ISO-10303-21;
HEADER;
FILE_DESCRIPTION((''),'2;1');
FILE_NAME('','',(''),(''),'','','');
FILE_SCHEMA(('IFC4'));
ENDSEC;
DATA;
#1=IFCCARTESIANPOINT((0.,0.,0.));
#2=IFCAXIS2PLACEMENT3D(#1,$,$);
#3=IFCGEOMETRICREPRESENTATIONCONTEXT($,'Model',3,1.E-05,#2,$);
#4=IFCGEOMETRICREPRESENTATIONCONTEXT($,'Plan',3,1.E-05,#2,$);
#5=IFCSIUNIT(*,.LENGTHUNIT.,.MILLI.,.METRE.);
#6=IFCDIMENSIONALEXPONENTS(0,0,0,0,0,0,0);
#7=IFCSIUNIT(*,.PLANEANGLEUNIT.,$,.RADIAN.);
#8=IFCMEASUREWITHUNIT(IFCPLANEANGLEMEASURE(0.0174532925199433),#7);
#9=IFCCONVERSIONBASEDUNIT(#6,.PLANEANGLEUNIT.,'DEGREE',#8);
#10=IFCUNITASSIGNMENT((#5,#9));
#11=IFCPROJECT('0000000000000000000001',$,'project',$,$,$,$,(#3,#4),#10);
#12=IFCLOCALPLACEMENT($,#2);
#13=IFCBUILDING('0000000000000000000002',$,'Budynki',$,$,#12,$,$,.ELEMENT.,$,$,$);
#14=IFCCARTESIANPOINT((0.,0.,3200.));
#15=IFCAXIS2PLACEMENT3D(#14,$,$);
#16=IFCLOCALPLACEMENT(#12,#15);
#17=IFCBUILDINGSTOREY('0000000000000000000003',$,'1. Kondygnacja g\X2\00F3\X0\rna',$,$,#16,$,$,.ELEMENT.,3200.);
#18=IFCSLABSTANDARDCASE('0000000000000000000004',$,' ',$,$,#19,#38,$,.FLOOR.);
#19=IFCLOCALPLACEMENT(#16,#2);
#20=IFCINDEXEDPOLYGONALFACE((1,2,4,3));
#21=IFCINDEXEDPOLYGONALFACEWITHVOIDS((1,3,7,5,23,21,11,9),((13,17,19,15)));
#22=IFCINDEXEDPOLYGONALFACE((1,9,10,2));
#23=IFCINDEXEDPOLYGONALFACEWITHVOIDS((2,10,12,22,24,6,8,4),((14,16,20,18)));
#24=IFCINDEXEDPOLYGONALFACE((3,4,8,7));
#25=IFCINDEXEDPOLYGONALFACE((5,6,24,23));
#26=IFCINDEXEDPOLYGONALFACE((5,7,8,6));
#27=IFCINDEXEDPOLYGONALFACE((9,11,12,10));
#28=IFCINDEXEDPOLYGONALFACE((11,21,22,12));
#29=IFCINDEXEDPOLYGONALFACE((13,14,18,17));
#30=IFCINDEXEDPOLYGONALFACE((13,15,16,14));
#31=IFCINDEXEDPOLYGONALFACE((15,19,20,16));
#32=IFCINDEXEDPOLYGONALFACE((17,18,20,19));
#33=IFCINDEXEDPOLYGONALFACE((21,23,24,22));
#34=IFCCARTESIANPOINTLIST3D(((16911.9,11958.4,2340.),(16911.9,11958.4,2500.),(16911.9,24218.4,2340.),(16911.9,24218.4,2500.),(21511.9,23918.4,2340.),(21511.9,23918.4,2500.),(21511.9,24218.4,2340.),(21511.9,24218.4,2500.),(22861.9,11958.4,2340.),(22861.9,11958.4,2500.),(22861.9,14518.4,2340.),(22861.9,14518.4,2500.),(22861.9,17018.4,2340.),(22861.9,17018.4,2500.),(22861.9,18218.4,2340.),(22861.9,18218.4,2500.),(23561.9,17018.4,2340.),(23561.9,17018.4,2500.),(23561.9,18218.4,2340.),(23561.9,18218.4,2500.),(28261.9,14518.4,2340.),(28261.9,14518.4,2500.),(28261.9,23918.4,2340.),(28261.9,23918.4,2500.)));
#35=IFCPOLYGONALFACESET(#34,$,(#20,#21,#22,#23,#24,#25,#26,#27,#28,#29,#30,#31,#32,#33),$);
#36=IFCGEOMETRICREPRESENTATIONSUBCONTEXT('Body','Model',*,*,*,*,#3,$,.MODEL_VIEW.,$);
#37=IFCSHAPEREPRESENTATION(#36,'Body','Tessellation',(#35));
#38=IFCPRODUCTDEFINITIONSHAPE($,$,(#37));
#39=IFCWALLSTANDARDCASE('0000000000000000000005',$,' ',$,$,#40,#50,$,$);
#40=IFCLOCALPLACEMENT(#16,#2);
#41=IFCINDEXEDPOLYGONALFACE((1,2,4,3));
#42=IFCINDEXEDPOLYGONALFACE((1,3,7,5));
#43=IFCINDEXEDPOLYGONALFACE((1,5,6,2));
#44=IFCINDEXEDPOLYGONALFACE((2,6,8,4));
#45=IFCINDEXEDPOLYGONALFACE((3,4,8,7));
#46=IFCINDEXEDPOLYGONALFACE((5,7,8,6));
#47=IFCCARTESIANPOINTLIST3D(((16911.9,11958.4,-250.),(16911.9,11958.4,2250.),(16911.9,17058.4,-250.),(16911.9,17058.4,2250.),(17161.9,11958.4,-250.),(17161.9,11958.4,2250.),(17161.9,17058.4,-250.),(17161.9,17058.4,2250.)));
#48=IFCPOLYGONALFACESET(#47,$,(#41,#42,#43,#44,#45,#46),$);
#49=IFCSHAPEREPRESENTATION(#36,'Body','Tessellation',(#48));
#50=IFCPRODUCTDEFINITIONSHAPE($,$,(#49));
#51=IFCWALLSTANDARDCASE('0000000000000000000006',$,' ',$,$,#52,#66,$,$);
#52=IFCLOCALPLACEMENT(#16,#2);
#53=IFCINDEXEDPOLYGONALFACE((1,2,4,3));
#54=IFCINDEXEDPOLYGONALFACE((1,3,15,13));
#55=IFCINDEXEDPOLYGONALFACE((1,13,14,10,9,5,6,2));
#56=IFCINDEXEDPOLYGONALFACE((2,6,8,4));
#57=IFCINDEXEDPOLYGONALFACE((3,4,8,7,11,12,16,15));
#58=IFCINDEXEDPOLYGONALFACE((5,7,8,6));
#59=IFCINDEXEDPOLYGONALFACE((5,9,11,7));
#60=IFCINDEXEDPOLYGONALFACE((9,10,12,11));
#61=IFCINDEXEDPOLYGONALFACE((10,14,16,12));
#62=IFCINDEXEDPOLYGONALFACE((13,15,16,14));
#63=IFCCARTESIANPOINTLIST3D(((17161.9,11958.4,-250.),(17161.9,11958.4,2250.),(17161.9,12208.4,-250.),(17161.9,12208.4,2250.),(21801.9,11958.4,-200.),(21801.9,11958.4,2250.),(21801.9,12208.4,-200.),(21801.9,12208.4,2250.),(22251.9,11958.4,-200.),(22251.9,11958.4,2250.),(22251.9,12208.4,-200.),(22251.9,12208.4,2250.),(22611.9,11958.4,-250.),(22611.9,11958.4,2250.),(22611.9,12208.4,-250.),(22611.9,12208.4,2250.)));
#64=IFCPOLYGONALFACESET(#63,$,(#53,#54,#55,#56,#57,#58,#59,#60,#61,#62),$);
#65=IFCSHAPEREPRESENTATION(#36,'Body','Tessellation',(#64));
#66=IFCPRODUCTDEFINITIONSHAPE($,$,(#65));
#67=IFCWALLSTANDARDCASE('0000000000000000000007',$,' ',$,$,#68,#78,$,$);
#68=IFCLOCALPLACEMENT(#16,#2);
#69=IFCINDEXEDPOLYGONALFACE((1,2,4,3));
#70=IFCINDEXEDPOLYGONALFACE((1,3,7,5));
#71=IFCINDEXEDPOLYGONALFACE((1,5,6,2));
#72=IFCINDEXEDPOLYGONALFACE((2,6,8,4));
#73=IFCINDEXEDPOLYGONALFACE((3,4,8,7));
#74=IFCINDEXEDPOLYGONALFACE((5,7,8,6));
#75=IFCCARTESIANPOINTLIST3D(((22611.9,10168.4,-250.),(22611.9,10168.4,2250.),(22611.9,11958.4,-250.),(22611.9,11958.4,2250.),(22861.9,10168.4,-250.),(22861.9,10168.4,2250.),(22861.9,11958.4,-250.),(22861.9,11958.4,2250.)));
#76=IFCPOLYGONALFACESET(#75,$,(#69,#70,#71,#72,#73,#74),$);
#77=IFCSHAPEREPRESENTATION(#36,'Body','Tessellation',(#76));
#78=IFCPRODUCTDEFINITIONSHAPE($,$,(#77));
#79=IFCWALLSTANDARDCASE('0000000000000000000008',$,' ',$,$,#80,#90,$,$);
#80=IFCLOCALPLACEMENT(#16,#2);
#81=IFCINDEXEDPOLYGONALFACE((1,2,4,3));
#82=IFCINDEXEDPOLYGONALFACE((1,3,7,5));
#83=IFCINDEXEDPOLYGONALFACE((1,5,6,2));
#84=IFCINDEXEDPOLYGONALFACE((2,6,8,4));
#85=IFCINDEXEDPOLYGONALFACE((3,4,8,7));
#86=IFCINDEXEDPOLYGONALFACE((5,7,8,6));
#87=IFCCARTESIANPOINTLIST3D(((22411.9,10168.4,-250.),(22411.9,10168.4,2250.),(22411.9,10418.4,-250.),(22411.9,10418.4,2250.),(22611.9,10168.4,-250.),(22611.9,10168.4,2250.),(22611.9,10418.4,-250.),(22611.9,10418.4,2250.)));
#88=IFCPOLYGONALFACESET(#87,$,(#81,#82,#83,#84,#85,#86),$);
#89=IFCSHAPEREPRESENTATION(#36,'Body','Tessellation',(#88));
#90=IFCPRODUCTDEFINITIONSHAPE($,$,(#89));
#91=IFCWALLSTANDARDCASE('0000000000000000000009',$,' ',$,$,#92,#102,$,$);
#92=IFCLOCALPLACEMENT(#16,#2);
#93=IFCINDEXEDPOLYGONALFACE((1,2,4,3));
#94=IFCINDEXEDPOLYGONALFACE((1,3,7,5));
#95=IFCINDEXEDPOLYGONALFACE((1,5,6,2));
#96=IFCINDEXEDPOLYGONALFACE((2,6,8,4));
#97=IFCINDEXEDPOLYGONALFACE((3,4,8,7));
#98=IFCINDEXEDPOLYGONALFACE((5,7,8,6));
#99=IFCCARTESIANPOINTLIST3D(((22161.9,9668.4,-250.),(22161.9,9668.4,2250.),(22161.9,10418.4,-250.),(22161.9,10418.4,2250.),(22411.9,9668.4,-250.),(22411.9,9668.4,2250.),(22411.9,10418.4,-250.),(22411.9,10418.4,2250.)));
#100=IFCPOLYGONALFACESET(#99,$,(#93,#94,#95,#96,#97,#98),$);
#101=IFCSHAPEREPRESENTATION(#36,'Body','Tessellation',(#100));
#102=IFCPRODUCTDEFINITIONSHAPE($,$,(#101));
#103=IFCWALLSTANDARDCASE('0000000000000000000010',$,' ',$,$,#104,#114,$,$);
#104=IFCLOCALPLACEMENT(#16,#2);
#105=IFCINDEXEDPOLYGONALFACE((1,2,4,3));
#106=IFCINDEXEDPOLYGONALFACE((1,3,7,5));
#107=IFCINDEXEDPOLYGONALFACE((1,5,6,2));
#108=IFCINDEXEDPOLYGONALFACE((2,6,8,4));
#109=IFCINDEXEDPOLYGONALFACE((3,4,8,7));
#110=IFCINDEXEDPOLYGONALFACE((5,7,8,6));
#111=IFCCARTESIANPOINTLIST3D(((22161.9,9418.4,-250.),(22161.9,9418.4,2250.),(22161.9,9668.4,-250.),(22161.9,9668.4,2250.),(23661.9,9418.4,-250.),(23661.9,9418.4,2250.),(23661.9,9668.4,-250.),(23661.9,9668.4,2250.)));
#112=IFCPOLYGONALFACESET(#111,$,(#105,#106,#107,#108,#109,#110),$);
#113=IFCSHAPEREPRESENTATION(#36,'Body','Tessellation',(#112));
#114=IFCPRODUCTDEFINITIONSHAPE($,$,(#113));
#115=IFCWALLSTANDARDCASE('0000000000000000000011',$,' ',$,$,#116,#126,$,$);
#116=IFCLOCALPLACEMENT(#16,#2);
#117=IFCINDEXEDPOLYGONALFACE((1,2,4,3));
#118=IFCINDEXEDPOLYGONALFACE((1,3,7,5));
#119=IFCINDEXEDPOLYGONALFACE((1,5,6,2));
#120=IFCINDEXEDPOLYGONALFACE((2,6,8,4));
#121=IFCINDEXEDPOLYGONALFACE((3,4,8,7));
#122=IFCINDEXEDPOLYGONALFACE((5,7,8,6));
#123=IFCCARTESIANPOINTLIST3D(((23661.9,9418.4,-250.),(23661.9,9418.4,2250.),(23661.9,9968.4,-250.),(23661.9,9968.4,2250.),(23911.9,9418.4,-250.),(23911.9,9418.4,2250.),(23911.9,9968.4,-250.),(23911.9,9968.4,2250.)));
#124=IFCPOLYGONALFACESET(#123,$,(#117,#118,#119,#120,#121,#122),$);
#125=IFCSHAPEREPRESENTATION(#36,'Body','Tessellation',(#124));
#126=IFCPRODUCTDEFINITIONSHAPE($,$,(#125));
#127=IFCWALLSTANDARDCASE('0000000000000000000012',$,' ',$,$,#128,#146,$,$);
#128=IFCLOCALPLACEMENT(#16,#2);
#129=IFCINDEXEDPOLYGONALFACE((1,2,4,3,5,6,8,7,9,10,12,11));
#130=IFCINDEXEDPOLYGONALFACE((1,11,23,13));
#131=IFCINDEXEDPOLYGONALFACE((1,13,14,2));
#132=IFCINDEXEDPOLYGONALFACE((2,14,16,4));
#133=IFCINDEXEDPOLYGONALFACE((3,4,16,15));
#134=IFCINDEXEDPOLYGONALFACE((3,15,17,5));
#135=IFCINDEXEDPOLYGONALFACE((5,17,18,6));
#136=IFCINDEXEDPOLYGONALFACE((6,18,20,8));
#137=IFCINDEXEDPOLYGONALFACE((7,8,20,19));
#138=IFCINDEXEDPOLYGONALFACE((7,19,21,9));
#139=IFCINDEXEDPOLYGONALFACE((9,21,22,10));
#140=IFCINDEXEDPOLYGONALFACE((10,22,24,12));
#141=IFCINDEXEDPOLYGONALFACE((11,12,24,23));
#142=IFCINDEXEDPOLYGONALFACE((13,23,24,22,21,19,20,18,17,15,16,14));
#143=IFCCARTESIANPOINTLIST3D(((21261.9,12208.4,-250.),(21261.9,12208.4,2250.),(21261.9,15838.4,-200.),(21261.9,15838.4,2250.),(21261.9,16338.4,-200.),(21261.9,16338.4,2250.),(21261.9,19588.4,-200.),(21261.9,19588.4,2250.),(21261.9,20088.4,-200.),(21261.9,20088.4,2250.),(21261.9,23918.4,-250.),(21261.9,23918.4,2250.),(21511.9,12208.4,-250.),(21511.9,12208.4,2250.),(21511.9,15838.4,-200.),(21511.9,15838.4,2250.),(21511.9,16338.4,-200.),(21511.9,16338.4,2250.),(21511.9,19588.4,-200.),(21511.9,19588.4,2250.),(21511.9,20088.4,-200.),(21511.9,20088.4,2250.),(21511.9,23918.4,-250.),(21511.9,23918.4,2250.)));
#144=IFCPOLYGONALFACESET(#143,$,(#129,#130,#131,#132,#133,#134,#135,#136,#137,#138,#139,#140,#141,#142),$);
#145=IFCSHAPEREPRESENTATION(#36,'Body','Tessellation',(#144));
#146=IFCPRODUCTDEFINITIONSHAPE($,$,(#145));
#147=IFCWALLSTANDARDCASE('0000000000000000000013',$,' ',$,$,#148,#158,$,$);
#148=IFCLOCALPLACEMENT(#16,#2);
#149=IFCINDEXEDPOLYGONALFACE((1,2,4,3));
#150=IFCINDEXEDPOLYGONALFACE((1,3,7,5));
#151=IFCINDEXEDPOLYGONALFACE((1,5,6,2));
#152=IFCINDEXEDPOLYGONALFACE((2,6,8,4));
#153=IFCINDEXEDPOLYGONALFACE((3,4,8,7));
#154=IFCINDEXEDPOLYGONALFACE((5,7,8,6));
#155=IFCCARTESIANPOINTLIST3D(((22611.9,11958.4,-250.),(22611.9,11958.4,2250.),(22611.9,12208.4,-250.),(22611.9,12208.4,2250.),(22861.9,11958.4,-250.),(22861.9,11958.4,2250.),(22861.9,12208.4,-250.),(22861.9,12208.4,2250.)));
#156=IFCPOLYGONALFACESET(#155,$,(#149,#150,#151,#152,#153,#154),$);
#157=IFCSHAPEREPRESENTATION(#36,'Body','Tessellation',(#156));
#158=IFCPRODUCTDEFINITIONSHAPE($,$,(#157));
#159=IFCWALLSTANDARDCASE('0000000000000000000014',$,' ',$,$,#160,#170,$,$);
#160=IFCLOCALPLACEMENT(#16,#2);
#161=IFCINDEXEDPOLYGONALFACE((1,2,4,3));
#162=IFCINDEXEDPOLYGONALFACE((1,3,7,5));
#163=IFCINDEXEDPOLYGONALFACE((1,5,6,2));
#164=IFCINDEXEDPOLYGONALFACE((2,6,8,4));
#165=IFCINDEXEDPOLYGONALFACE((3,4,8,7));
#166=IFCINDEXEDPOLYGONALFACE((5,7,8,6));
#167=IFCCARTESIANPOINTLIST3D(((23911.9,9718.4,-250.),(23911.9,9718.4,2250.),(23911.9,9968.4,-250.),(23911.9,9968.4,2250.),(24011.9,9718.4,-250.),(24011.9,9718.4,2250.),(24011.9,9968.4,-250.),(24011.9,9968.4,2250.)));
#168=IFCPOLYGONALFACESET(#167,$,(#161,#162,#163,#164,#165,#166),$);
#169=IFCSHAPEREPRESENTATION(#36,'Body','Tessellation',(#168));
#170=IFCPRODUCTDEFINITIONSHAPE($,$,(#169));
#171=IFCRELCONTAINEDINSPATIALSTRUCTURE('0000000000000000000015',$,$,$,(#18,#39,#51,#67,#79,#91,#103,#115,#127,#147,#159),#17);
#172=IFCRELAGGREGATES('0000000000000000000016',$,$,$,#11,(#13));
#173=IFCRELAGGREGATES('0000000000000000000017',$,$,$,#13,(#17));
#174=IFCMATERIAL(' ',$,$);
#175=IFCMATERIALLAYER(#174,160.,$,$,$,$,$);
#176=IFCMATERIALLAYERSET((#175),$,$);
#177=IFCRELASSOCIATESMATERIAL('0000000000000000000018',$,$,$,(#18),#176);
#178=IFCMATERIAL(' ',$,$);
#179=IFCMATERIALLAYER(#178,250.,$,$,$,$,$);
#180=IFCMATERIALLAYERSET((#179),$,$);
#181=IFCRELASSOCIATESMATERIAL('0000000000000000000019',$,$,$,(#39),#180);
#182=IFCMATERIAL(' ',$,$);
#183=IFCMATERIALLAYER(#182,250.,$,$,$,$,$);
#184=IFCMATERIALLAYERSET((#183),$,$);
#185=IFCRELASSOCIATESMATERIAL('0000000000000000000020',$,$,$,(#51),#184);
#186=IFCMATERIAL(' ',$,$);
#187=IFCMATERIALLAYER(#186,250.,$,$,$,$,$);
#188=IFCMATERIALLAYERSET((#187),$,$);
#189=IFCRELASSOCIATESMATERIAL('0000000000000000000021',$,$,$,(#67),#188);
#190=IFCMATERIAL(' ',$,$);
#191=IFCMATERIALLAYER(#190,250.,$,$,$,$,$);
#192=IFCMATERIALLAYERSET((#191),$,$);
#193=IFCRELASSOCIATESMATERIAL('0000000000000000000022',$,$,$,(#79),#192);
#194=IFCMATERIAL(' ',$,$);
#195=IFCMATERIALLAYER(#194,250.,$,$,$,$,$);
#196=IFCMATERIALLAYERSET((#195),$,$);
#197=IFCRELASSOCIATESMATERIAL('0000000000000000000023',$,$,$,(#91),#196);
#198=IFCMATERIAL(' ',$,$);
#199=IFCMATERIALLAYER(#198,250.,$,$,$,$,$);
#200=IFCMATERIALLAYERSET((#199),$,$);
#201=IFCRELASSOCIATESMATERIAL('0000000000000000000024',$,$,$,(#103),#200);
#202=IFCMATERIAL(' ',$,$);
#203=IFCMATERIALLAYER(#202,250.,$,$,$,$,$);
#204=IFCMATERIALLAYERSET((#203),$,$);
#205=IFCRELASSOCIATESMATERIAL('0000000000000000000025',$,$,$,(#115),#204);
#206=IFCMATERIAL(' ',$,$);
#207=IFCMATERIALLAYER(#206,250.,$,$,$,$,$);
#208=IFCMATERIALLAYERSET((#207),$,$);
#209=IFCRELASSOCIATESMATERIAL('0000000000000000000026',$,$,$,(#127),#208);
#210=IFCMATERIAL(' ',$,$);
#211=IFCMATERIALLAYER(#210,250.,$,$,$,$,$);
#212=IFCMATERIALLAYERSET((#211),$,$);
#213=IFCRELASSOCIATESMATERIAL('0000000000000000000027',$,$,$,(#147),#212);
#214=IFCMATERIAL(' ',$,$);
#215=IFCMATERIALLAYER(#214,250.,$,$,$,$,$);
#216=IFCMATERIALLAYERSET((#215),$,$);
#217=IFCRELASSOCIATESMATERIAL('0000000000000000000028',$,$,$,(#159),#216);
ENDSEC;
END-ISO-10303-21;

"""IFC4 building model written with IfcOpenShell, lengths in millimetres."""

from ifc_helpers import new_model, entity, si_unit, converted_unit, frame, frame_2d, origin, origin_with_axes, place, context, subcontext, project, spatial, polyline, rectangle, outline, extrude, clip, bounded_halfspace, material, layer, layer_set, layer_usage, element, save


model = new_model("IFC4")

# Units and contexts
model_context = context("Model", 3, precision=1e-05, world=origin())
plan_context = context("Plan", 3, precision=1e-05, world=origin())
body_context = subcontext(model_context, "Body", "Model", "MODEL_VIEW")
ifc_project = project(units=[si_unit("LENGTHUNIT", "METRE", prefix="MILLI"), converted_unit("PLANEANGLEUNIT", "DEGREE", entity("IfcPlaneAngleMeasure", 0.0174532925199433), si_unit("PLANEANGLEUNIT", "RADIAN"), dimensions=[0, 0, 0, 0, 0, 0, 0])], contexts=[model_context, plan_context])

# Building, storey
building_placement = place(None, origin())
building = spatial("IfcBuilding", under=ifc_project, at=building_placement, Name="Budynki", CompositionType="ELEMENT")
storey_placement = place(building_placement, frame((0.0, 0.0, 3200.0)))
storey = spatial("IfcBuildingStorey", under=building, at=storey_placement, Name="1. Kondygnacja górna", CompositionType="ELEMENT", Elevation=3200.0)

# Slab
ifc_material_1 = material(Name=" ")
ifc_layer_1 = layer(ifc_material_1, 160.0)
ifc_layer_set_1 = layer_set([ifc_layer_1])
ifc_layer_usage_1 = layer_usage(ifc_layer_set_1, "AXIS3", "POSITIVE", 0.0)
slab_1_placement = place(storey_placement, frame((16911.9, 11958.4, 2340.0)))
element("IfcSlabStandardCase", 1, at=slab_1_placement, inside=storey, material=ifc_layer_usage_1, Name=" ", PredefinedType="FLOOR", context=body_context, shape_type="SweptSolid", body=[
    extrude(outline(polyline([(0.0, 0.0), (5950.0, 0.0), (5950.0, 2560.0), (11350.0, 2560.0), (11350.0, 11960.0), (4600.0, 11960.0), (4600.0, 12260.0), (0.0, 12260.0), (0.0, 0.0)]), holes=[polyline([(5950.0, 5060.0), (5950.0, 6260.0), (6650.0, 6260.0), (6650.0, 5060.0), (5950.0, 5060.0)])]), origin_with_axes(), (0.0, 0.0, 1.0), 160.0),
])

# Walls
ifc_material_2 = material(Name=" ")
ifc_layer_2 = layer(ifc_material_2, 250.0)
ifc_layer_set_2 = layer_set([ifc_layer_2])
ifc_layer_usage_2 = layer_usage(ifc_layer_set_2, "AXIS2", "POSITIVE", 0.0)
wall_1_placement = place(storey_placement, frame((17161.9, 11958.4, -250.0), z_axis=(0.0, 0.0, 1.0), x_axis=(0.0, 1.0, 0.0)))
element("IfcWallStandardCase", 2, at=wall_1_placement, inside=storey, material=ifc_layer_usage_2, Name=" ", context=body_context, shape_type="SweptSolid", body=[
    extrude(rectangle(XDim=5100.0, YDim=250.0, at=frame_2d((2550.0, 125.0), x_axis=(1.0, 0.0))), origin_with_axes(), (0.0, 0.0, 1.0), 2500.0),
])
ifc_material_3 = material(Name=" ")
ifc_layer_3 = layer(ifc_material_3, 250.0)
ifc_layer_set_3 = layer_set([ifc_layer_3])
ifc_layer_usage_3 = layer_usage(ifc_layer_set_3, "AXIS2", "POSITIVE", 0.0)
wall_2_placement = place(storey_placement, frame((22611.9, 12208.4, -250.0), z_axis=(0.0, 0.0, 1.0), x_axis=(-1.0, 0.0, 0.0)))
element("IfcWallStandardCase", 3, at=wall_2_placement, inside=storey, material=ifc_layer_usage_3, Name=" ", context=body_context, shape_type="Clipping", body=[
    clip(extrude(rectangle(XDim=5450.0, YDim=250.0, at=frame_2d((2725.0, 125.0), x_axis=(1.0, 0.0))), origin_with_axes(), (0.0, 0.0, 1.0), 2500.0), bounded_halfspace(frame((585.0, 125.0, 50.0), z_axis=(0.0, 0.0, -1.0), x_axis=(0.0, 1.0, 0.0)), True, origin_with_axes(), polyline([(810.0, 0.0), (810.0, 250.0), (360.0, 250.0), (360.0, 0.0), (810.0, 0.0)]))),
])
ifc_material_4 = material(Name=" ")
ifc_layer_4 = layer(ifc_material_4, 250.0)
ifc_layer_set_4 = layer_set([ifc_layer_4])
ifc_layer_usage_4 = layer_usage(ifc_layer_set_4, "AXIS2", "POSITIVE", 0.0)
wall_3_placement = place(storey_placement, frame((22611.9, 11958.4, -250.0), z_axis=(0.0, 0.0, 1.0), x_axis=(0.0, -1.0, 0.0)))
element("IfcWallStandardCase", 4, at=wall_3_placement, inside=storey, material=ifc_layer_usage_4, Name=" ", context=body_context, shape_type="SweptSolid", body=[
    extrude(rectangle(XDim=1790.0, YDim=250.0, at=frame_2d((895.0, 125.0), x_axis=(1.0, 0.0))), origin_with_axes(), (0.0, 0.0, 1.0), 2500.0),
])
ifc_material_5 = material(Name=" ")
ifc_layer_5 = layer(ifc_material_5, 250.0)
ifc_layer_set_5 = layer_set([ifc_layer_5])
ifc_layer_usage_5 = layer_usage(ifc_layer_set_5, "AXIS2", "POSITIVE", 0.0)
wall_4_placement = place(storey_placement, frame((22611.9, 10418.4, -250.0), z_axis=(0.0, 0.0, 1.0), x_axis=(-1.0, 0.0, 0.0)))
element("IfcWallStandardCase", 5, at=wall_4_placement, inside=storey, material=ifc_layer_usage_5, Name=" ", context=body_context, shape_type="SweptSolid", body=[
    extrude(rectangle(XDim=200.0, YDim=250.0, at=frame_2d((100.0, 125.0), x_axis=(1.0, 0.0))), origin_with_axes(), (0.0, 0.0, 1.0), 2500.0),
])
ifc_material_6 = material(Name=" ")
ifc_layer_6 = layer(ifc_material_6, 250.0)
ifc_layer_set_6 = layer_set([ifc_layer_6])
ifc_layer_usage_6 = layer_usage(ifc_layer_set_6, "AXIS2", "POSITIVE", 0.0)
wall_5_placement = place(storey_placement, frame((22161.9, 10418.4, -250.0), z_axis=(0.0, 0.0, 1.0), x_axis=(0.0, -1.0, 0.0)))
element("IfcWallStandardCase", 6, at=wall_5_placement, inside=storey, material=ifc_layer_usage_6, Name=" ", context=body_context, shape_type="SweptSolid", body=[
    extrude(rectangle(XDim=750.0, YDim=250.0, at=frame_2d((375.0, 125.0), x_axis=(1.0, 0.0))), origin_with_axes(), (0.0, 0.0, 1.0), 2500.0),
])
ifc_material_7 = material(Name=" ")
ifc_layer_7 = layer(ifc_material_7, 250.0)
ifc_layer_set_7 = layer_set([ifc_layer_7])
ifc_layer_usage_7 = layer_usage(ifc_layer_set_7, "AXIS2", "POSITIVE", 0.0)
wall_6_placement = place(storey_placement, frame((22161.9, 9418.4, -250.0)))
element("IfcWallStandardCase", 7, at=wall_6_placement, inside=storey, material=ifc_layer_usage_7, Name=" ", context=body_context, shape_type="SweptSolid", body=[
    extrude(rectangle(XDim=1500.0, YDim=250.0, at=frame_2d((750.0, 125.0), x_axis=(1.0, 0.0))), origin_with_axes(), (0.0, 0.0, 1.0), 2500.0),
])
ifc_material_8 = material(Name=" ")
ifc_layer_8 = layer(ifc_material_8, 250.0)
ifc_layer_set_8 = layer_set([ifc_layer_8])
ifc_layer_usage_8 = layer_usage(ifc_layer_set_8, "AXIS2", "POSITIVE", 0.0)
wall_7_placement = place(storey_placement, frame((23911.9, 9418.4, -250.0), z_axis=(0.0, 0.0, 1.0), x_axis=(0.0, 1.0, 0.0)))
element("IfcWallStandardCase", 8, at=wall_7_placement, inside=storey, material=ifc_layer_usage_8, Name=" ", context=body_context, shape_type="SweptSolid", body=[
    extrude(rectangle(XDim=550.0, YDim=250.0, at=frame_2d((275.0, 125.0), x_axis=(1.0, 0.0))), origin_with_axes(), (0.0, 0.0, 1.0), 2500.0),
])
ifc_material_9 = material(Name=" ")
ifc_layer_9 = layer(ifc_material_9, 250.0)
ifc_layer_set_9 = layer_set([ifc_layer_9])
ifc_layer_usage_9 = layer_usage(ifc_layer_set_9, "AXIS2", "POSITIVE", 0.0)
wall_8_placement = place(storey_placement, frame((21511.9, 12208.4, -250.0), z_axis=(0.0, 0.0, 1.0), x_axis=(0.0, 1.0, 0.0)))
element("IfcWallStandardCase", 9, at=wall_8_placement, inside=storey, material=ifc_layer_usage_9, Name=" ", context=body_context, shape_type="Clipping", body=[
    clip(clip(extrude(rectangle(XDim=11710.0, YDim=250.0, at=frame_2d((5855.0, 125.0), x_axis=(1.0, 0.0))), origin_with_axes(), (0.0, 0.0, 1.0), 2500.0), bounded_halfspace(frame((7630.0, 125.0, 50.0), z_axis=(0.0, 0.0, -1.0), x_axis=(0.0, -1.0, 0.0)), True, origin_with_axes(), polyline([(7380.0, 250.0), (7380.0, 0.0), (7880.0, 0.0), (7880.0, 250.0), (7380.0, 250.0)]))), bounded_halfspace(frame((3880.0, 125.0, 50.0), z_axis=(0.0, 0.0, -1.0), x_axis=(0.0, -1.0, 0.0)), True, origin_with_axes(), polyline([(3630.0, 250.0), (3630.0, 0.0), (4130.0, 0.0), (4130.0, 250.0), (3630.0, 250.0)]))),
])
ifc_material_10 = material(Name=" ")
ifc_layer_10 = layer(ifc_material_10, 250.0)
ifc_layer_set_10 = layer_set([ifc_layer_10])
ifc_layer_usage_10 = layer_usage(ifc_layer_set_10, "AXIS2", "POSITIVE", 0.0)
wall_9_placement = place(storey_placement, frame((22611.9, 12208.4, -250.0), z_axis=(0.0, 0.0, 1.0), x_axis=(0.0, -1.0, 0.0)))
element("IfcWallStandardCase", 10, at=wall_9_placement, inside=storey, material=ifc_layer_usage_10, Name=" ", context=body_context, shape_type="SweptSolid", body=[
    extrude(rectangle(XDim=250.0, YDim=250.0, at=frame_2d((125.0, 125.0), x_axis=(1.0, 0.0))), origin_with_axes(), (0.0, 0.0, 1.0), 2500.0),
])
ifc_material_11 = material(Name=" ")
ifc_layer_11 = layer(ifc_material_11, 250.0)
ifc_layer_set_11 = layer_set([ifc_layer_11])
ifc_layer_usage_11 = layer_usage(ifc_layer_set_11, "AXIS2", "POSITIVE", 0.0)
wall_10_placement = place(storey_placement, frame((23911.9, 9718.4, -250.0)))
element("IfcWallStandardCase", 11, at=wall_10_placement, inside=storey, material=ifc_layer_usage_11, Name=" ", context=body_context, shape_type="SweptSolid", body=[
    extrude(rectangle(XDim=100.0, YDim=250.0, at=frame_2d((50.0, 125.0), x_axis=(1.0, 0.0))), origin_with_axes(), (0.0, 0.0, 1.0), 2500.0),
])

save(model, "model.ifc")
